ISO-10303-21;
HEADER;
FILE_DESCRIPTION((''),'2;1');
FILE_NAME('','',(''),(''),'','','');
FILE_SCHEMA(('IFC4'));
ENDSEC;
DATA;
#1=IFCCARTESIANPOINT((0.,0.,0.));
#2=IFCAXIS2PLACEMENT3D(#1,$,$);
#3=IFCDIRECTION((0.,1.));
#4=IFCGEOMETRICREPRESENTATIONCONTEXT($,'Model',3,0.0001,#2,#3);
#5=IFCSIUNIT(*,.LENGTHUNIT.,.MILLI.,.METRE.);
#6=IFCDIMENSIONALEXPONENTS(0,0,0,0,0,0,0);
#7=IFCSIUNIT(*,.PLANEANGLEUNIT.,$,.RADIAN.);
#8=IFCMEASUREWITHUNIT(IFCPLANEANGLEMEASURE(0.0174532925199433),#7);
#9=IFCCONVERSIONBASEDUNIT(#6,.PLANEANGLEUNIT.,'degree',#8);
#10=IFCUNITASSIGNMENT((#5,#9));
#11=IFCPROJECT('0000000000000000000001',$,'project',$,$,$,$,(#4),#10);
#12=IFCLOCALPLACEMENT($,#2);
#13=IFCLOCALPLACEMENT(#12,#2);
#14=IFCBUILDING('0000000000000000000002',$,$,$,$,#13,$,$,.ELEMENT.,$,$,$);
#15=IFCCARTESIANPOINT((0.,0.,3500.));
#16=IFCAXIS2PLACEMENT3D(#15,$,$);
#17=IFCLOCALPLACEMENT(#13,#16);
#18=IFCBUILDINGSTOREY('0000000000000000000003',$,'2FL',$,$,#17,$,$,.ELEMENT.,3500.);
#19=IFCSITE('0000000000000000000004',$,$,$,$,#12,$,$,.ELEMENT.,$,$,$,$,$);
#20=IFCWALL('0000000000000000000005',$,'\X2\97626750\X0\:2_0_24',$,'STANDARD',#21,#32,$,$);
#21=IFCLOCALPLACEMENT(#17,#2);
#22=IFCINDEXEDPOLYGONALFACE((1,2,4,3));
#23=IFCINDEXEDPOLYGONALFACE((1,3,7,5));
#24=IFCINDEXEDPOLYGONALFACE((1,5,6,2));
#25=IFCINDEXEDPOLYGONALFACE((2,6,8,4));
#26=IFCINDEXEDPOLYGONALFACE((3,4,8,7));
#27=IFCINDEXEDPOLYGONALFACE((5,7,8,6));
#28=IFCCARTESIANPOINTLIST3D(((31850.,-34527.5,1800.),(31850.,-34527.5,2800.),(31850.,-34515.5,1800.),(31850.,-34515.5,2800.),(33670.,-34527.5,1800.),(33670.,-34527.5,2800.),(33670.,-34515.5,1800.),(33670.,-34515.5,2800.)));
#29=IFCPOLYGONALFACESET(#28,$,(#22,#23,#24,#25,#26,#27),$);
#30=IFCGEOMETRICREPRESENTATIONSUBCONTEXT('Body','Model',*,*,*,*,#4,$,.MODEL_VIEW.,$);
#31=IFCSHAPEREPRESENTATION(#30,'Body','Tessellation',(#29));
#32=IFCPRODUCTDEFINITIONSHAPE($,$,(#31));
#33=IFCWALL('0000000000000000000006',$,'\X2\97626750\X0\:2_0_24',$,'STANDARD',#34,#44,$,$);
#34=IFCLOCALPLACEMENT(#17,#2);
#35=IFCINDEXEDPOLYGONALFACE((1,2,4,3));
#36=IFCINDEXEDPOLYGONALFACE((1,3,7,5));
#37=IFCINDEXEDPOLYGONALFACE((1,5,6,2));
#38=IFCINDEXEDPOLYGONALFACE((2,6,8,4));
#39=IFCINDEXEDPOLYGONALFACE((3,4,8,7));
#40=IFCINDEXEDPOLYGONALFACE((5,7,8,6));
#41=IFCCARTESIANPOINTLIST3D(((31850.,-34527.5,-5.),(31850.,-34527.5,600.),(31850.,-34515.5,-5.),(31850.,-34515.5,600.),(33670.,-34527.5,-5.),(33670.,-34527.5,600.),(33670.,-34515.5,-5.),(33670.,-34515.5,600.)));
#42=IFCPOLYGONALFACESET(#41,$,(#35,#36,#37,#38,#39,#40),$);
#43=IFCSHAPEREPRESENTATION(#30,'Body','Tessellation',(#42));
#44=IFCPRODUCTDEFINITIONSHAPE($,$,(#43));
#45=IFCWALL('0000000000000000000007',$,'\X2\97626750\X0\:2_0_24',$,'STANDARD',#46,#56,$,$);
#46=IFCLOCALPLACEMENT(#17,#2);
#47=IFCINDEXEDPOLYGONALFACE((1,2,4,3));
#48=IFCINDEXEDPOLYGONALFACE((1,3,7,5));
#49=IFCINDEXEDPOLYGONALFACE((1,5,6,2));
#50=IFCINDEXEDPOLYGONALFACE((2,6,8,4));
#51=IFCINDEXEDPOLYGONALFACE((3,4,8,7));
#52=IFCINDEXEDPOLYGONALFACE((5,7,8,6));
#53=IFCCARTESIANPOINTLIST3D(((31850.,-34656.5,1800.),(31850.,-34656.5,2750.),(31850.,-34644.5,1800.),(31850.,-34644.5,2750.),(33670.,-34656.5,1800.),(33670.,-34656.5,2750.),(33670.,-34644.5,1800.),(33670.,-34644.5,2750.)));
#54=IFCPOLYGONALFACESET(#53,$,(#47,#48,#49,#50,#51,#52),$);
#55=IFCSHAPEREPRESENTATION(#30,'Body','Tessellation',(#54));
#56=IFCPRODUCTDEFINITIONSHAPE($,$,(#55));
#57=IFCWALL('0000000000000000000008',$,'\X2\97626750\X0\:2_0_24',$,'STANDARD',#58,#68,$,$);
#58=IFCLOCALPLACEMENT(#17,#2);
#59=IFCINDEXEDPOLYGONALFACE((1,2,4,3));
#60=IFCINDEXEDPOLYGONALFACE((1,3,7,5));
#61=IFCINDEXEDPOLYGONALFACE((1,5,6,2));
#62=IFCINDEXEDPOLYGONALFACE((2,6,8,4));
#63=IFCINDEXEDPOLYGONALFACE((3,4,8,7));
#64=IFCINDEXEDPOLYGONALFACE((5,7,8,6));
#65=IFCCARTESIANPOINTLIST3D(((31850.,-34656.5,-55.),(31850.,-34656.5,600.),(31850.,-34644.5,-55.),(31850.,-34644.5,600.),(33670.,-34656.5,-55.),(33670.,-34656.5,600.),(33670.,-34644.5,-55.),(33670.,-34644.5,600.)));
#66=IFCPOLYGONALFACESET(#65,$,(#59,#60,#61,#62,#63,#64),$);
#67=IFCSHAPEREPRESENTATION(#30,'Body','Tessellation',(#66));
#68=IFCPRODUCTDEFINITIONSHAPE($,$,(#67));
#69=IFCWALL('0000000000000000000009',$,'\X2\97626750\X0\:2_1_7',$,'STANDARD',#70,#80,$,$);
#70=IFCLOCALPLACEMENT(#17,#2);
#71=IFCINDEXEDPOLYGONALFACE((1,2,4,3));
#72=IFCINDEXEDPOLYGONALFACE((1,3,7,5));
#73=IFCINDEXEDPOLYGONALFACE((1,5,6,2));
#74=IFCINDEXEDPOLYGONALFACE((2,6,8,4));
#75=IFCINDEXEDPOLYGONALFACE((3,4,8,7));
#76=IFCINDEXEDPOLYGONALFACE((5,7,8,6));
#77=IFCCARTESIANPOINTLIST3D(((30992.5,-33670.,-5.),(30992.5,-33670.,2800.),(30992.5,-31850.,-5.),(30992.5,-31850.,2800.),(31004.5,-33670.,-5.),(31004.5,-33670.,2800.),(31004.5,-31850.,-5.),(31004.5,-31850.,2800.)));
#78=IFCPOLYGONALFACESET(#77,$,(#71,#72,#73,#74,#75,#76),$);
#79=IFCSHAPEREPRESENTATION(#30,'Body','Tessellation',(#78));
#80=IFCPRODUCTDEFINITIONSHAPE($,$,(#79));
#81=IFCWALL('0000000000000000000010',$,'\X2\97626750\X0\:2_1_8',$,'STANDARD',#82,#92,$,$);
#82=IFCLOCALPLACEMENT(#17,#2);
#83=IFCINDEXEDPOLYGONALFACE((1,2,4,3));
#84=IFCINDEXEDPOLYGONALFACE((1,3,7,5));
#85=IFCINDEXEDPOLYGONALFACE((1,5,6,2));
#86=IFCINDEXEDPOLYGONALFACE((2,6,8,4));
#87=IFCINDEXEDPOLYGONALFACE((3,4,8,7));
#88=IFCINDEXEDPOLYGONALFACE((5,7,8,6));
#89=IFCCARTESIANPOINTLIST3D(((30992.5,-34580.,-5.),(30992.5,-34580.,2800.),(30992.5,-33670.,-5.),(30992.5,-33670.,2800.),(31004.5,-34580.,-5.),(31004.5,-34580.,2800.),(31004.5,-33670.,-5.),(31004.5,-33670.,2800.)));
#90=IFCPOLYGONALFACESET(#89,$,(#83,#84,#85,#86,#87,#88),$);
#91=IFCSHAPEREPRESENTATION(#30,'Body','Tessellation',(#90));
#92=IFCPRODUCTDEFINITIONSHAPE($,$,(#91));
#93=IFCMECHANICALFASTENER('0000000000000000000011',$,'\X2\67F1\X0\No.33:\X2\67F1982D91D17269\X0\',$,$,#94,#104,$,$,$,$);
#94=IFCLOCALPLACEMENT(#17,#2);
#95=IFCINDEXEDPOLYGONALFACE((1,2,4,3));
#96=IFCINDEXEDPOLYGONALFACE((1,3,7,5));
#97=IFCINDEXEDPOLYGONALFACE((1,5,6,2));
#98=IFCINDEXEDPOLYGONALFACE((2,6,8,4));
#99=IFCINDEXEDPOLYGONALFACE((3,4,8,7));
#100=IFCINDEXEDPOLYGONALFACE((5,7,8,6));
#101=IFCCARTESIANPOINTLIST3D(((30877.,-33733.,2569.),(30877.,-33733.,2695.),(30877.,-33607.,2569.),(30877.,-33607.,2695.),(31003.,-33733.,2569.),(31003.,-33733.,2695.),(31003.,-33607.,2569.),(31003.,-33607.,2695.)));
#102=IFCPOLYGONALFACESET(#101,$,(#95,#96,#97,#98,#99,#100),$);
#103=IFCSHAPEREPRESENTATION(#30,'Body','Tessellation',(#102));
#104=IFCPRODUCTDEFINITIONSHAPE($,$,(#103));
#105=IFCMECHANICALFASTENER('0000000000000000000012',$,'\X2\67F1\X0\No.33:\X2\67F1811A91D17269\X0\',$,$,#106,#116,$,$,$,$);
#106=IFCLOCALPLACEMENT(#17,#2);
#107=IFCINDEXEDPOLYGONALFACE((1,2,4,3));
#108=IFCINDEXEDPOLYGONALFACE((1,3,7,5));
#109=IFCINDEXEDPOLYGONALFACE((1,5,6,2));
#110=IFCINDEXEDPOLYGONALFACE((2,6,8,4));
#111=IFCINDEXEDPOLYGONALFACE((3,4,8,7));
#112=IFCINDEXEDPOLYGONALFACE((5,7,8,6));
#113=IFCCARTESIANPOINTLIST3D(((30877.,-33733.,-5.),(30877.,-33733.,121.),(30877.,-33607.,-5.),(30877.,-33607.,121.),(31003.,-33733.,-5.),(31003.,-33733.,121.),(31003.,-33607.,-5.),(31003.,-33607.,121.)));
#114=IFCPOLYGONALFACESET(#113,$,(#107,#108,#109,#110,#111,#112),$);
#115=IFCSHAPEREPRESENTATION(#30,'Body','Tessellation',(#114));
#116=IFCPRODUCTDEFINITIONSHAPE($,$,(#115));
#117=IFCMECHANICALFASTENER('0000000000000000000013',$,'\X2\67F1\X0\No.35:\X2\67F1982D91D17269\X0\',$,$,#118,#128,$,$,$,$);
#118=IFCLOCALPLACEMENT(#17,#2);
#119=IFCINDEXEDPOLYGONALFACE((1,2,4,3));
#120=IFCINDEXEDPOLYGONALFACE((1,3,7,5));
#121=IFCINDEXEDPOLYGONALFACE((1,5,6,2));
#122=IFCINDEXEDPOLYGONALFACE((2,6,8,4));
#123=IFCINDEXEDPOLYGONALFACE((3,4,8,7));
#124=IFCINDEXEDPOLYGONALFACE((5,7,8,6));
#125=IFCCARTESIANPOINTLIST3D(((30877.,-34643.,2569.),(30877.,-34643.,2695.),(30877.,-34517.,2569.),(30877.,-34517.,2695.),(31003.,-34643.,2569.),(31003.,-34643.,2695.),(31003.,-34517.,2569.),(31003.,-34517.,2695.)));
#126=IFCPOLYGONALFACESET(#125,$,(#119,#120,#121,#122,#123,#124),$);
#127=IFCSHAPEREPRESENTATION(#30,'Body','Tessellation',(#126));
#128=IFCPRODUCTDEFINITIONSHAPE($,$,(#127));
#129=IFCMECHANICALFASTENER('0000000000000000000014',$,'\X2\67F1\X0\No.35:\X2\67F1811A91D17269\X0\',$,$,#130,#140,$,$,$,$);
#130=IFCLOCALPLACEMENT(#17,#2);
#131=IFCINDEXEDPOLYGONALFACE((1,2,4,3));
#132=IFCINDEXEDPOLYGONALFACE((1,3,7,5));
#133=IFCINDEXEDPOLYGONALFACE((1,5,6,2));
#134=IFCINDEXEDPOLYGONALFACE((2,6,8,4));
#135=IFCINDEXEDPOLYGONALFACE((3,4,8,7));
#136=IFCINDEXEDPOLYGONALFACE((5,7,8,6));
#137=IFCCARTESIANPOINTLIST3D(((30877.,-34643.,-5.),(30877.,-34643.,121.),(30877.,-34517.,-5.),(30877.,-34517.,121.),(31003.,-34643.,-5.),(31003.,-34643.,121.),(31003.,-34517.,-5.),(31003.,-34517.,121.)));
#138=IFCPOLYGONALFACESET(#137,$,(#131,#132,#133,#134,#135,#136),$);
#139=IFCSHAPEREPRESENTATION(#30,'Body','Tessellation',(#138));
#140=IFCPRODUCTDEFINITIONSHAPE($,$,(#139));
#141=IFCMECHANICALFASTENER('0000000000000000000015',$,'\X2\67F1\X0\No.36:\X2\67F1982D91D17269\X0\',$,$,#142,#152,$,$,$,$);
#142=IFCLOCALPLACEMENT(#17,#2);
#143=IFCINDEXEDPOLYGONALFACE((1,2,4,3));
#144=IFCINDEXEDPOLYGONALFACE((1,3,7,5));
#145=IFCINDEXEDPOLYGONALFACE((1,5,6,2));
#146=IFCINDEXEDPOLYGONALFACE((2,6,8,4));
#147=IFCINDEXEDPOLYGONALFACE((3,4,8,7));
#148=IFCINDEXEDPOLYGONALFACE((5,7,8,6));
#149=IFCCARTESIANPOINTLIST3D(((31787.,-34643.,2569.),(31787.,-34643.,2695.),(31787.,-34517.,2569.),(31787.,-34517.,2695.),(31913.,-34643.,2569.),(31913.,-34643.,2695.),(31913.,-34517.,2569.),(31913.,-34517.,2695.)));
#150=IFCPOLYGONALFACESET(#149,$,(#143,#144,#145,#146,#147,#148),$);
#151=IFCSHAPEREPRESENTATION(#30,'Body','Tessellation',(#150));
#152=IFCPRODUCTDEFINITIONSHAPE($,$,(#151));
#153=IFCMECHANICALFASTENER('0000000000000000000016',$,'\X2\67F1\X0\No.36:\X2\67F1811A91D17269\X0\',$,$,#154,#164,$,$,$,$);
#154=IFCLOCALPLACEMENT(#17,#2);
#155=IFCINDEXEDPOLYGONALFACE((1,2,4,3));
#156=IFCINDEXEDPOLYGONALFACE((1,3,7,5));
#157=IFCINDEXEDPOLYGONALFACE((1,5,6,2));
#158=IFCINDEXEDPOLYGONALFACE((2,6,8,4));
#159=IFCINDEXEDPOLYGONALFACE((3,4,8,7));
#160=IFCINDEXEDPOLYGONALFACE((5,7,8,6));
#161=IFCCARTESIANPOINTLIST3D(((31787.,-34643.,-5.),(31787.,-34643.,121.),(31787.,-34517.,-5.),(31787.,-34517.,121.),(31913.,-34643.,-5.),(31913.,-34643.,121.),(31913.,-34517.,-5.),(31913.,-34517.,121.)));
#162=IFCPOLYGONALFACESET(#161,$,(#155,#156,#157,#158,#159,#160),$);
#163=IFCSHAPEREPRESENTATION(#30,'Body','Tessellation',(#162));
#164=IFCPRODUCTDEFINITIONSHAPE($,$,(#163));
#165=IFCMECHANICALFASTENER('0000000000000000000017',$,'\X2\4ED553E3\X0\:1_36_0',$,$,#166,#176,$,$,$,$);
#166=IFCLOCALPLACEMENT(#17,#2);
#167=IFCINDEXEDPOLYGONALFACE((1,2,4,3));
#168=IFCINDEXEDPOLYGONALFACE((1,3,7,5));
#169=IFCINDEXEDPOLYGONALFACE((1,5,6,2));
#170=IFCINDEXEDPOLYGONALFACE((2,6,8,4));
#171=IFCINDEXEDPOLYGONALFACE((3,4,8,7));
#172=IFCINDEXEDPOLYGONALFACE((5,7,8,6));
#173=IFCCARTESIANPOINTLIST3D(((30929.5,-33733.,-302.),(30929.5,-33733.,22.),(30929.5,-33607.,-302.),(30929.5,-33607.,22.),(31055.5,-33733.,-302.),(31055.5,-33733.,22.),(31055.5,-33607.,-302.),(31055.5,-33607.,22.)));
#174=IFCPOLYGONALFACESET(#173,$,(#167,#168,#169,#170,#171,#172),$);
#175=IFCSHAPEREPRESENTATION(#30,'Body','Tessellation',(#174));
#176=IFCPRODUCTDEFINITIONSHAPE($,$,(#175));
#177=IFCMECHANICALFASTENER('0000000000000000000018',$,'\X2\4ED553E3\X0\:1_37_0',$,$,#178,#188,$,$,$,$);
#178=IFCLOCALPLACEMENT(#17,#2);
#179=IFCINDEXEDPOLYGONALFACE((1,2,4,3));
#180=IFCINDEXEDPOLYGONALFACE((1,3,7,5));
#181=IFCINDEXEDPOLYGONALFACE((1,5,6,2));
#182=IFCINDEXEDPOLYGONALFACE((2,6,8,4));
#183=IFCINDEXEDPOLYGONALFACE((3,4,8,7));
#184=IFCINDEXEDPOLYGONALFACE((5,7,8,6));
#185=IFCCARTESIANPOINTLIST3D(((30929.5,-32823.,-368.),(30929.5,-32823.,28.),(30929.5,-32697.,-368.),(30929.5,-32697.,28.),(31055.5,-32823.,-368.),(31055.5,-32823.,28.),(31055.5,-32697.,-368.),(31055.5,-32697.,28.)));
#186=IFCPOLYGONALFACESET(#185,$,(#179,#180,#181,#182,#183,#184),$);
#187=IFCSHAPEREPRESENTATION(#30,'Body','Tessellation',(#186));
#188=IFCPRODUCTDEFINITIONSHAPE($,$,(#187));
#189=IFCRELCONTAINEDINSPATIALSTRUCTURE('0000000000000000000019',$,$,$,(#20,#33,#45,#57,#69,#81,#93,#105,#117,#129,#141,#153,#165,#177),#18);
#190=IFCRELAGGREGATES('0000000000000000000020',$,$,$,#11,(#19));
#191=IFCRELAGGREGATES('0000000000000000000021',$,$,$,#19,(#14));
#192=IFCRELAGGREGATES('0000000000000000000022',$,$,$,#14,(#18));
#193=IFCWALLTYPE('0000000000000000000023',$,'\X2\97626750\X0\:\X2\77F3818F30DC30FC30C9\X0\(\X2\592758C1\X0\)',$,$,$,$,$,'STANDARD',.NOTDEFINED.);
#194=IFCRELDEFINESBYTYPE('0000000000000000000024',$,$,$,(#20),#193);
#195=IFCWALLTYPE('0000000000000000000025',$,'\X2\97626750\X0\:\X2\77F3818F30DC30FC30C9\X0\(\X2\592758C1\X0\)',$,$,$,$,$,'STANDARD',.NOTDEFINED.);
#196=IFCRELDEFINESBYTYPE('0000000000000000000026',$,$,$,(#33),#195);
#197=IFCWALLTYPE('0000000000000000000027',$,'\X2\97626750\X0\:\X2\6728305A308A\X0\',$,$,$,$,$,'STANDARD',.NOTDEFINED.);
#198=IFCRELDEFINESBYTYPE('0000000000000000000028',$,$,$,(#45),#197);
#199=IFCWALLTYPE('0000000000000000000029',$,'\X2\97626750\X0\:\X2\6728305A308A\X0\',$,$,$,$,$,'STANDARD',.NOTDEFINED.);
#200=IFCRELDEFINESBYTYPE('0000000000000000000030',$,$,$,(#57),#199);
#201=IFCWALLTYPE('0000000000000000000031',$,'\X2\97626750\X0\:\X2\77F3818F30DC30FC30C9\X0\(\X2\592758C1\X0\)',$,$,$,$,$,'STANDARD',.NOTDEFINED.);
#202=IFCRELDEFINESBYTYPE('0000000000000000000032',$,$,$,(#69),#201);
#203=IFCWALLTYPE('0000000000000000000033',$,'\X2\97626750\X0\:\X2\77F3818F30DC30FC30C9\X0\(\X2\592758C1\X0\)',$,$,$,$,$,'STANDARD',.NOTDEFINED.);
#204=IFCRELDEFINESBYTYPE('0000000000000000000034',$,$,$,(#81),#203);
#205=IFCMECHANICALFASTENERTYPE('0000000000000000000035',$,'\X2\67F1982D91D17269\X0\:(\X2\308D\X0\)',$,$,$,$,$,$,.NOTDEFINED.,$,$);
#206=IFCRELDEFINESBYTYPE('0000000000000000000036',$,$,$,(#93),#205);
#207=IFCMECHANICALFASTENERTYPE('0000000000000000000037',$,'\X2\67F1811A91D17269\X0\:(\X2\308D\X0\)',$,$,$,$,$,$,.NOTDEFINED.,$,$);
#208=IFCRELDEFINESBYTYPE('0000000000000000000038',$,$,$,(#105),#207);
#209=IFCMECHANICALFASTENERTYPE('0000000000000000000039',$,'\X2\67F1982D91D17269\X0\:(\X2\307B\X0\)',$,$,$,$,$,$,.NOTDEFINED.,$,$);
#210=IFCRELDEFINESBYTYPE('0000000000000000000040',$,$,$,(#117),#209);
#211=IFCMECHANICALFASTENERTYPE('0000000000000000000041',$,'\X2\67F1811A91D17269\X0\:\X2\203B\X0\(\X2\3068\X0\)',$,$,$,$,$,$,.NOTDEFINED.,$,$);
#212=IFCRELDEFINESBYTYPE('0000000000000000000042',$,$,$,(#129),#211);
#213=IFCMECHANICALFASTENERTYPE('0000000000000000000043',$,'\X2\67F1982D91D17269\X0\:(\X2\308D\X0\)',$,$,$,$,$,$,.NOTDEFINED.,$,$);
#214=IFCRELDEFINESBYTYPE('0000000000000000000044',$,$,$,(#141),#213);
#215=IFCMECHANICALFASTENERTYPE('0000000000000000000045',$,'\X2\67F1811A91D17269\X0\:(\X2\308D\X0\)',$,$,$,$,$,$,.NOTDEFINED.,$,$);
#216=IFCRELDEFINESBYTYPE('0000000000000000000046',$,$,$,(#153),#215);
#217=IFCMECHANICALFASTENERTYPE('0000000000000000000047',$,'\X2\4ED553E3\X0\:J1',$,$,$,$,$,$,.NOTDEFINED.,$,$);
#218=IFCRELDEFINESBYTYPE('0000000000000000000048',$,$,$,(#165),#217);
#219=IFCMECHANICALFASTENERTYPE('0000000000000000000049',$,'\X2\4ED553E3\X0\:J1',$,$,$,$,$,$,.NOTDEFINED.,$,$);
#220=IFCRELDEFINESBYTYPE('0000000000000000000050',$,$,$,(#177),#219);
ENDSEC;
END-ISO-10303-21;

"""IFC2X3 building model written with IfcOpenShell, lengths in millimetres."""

from ifc_helpers import new_model, entity, si_unit, converted_unit, direction, frame, origin, origin_with_axes, origin_2d, place, context, subcontext, project, spatial, polyline, rectangle, outline, extrude, type_object, element, save


model = new_model("IFC2X3")

# Units and contexts
model_context = context("Model", 3, precision=0.0001, world=origin(), true_north=direction((0.0, 1.0)))
body_context = subcontext(model_context, "Body", "Model", "MODEL_VIEW")
ifc_project = project(units=[si_unit("LENGTHUNIT", "METRE", prefix="MILLI"), converted_unit("PLANEANGLEUNIT", "degree", entity("IfcPlaneAngleMeasure", 0.0174532925199433), si_unit("PLANEANGLEUNIT", "RADIAN"), dimensions=[0, 0, 0, 0, 0, 0, 0])], contexts=[model_context])

# Site, building, storey
site_placement = place(None, origin())
site = spatial("IfcSite", under=ifc_project, at=site_placement, CompositionType="ELEMENT")
building_placement = place(site_placement, origin())
building = spatial("IfcBuilding", under=site, at=building_placement, CompositionType="ELEMENT")
storey_placement = place(building_placement, frame((0.0, 0.0, 3500.0)))
storey = spatial("IfcBuildingStorey", under=building, at=storey_placement, Name="2FL", CompositionType="ELEMENT", Elevation=3500.0)

# Walls
wall_type_1 = type_object("IfcWallType", Name="面材:石膏ボード(大壁)", ElementType="STANDARD", PredefinedType="NOTDEFINED")
wall_1_placement = place(storey_placement, frame((32760.0, -34515.5, 1800.0), z_axis=(0.0, -1.0, 0.0), x_axis=(1.0, 0.0, 0.0)))
element("IfcWall", 1, at=wall_1_placement, inside=storey, type_object=wall_type_1, Name="面材:2_0_24", ObjectType="STANDARD", context=body_context, shape_type="SweptSolid", body=[
    extrude(outline(polyline([(-910.0, 0.0, 0.0), (-910.0, 1000.0, 0.0), (910.0, 1000.0, 0.0), (910.0, 0.0, 0.0), (-910.0, 0.0, 0.0)])), origin_with_axes(), (0.0, 0.0, 1.0), 12.0),
])
wall_type_2 = type_object("IfcWallType", Name="面材:石膏ボード(大壁)", ElementType="STANDARD", PredefinedType="NOTDEFINED")
wall_2_placement = place(storey_placement, frame((32760.0, -34515.5, -5.0), z_axis=(0.0, -1.0, 0.0), x_axis=(1.0, 0.0, 0.0)))
element("IfcWall", 2, at=wall_2_placement, inside=storey, type_object=wall_type_2, Name="面材:2_0_24", ObjectType="STANDARD", context=body_context, shape_type="SweptSolid", body=[
    extrude(outline(polyline([(-910.0, 605.0, 0.0), (910.0, 605.0, 0.0), (910.0, 0.0, 0.0), (-910.0, 0.0, 0.0), (-910.0, 605.0, 0.0)])), origin_with_axes(), (0.0, 0.0, 1.0), 12.0),
])
wall_type_3 = type_object("IfcWallType", Name="面材:木ずり", ElementType="STANDARD", PredefinedType="NOTDEFINED")
wall_3_placement = place(storey_placement, frame((32760.0, -34644.5, 1800.0), z_axis=(0.0, -1.0, 0.0), x_axis=(1.0, 0.0, 0.0)))
element("IfcWall", 3, at=wall_3_placement, inside=storey, type_object=wall_type_3, Name="面材:2_0_24", ObjectType="STANDARD", context=body_context, shape_type="SweptSolid", body=[
    extrude(outline(polyline([(-910.0, 0.0, 0.0), (-910.0, 950.0, 0.0), (910.0, 950.0, 0.0), (910.0, 0.0, 0.0), (-910.0, 0.0, 0.0)])), origin_with_axes(), (0.0, 0.0, 1.0), 12.0),
])
wall_type_4 = type_object("IfcWallType", Name="面材:木ずり", ElementType="STANDARD", PredefinedType="NOTDEFINED")
wall_4_placement = place(storey_placement, frame((32760.0, -34644.5, -55.0), z_axis=(0.0, -1.0, 0.0), x_axis=(1.0, 0.0, 0.0)))
element("IfcWall", 4, at=wall_4_placement, inside=storey, type_object=wall_type_4, Name="面材:2_0_24", ObjectType="STANDARD", context=body_context, shape_type="SweptSolid", body=[
    extrude(outline(polyline([(-910.0, 655.0, 0.0), (910.0, 655.0, 0.0), (910.0, 0.0, 0.0), (-910.0, 0.0, 0.0), (-910.0, 655.0, 0.0)])), origin_with_axes(), (0.0, 0.0, 1.0), 12.0),
])
wall_type_5 = type_object("IfcWallType", Name="面材:石膏ボード(大壁)", ElementType="STANDARD", PredefinedType="NOTDEFINED")
wall_5_placement = place(storey_placement, frame((31004.5, -32760.0, -5.0), z_axis=(-1.0, 0.0, 0.0), x_axis=(0.0, -1.0, 0.0)))
element("IfcWall", 5, at=wall_5_placement, inside=storey, type_object=wall_type_5, Name="面材:2_1_7", ObjectType="STANDARD", context=body_context, shape_type="SweptSolid", body=[
    extrude(outline(polyline([(910.0, 0.0, 0.0), (-910.0, 0.0, 0.0), (-910.0, 2805.0, 0.0), (910.0, 2805.0, 0.0), (910.0, 0.0, 0.0)])), origin_with_axes(), (0.0, 0.0, 1.0), 12.0),
])
wall_type_6 = type_object("IfcWallType", Name="面材:石膏ボード(大壁)", ElementType="STANDARD", PredefinedType="NOTDEFINED")
wall_6_placement = place(storey_placement, frame((31004.5, -34125.0, -5.0), z_axis=(-1.0, 0.0, 0.0), x_axis=(0.0, -1.0, 0.0)))
element("IfcWall", 6, at=wall_6_placement, inside=storey, type_object=wall_type_6, Name="面材:2_1_8", ObjectType="STANDARD", context=body_context, shape_type="SweptSolid", body=[
    extrude(outline(polyline([(455.0, 0.0, 0.0), (-455.0, 0.0, 0.0), (-455.0, 2805.0, 0.0), (455.0, 2805.0, 0.0), (455.0, 0.0, 0.0)])), origin_with_axes(), (0.0, 0.0, 1.0), 12.0),
])

# Mechanical fasteners
mechanical_fastener_type_1 = type_object("IfcMechanicalFastenerType", Name="柱頭金物:(ろ)")
mechanical_fastener_1_placement = place(storey_placement, frame((30940.0, -33670.0, 2569.0)))
element("IfcMechanicalFastener", 7, at=mechanical_fastener_1_placement, inside=storey, type_object=mechanical_fastener_type_1, Name="柱No.33:柱頭金物", context=body_context, shape_type="SweptSolid", body=[
    extrude(rectangle(XDim=126.0, YDim=126.0, at=origin_2d()), origin_with_axes(), (0.0, 0.0, 1.0), 126.0),
])
mechanical_fastener_type_2 = type_object("IfcMechanicalFastenerType", Name="柱脚金物:(ろ)")
mechanical_fastener_2_placement = place(storey_placement, frame((30940.0, -33670.0, -5.0)))
element("IfcMechanicalFastener", 8, at=mechanical_fastener_2_placement, inside=storey, type_object=mechanical_fastener_type_2, Name="柱No.33:柱脚金物", context=body_context, shape_type="SweptSolid", body=[
    extrude(rectangle(XDim=126.0, YDim=126.0, at=origin_2d()), origin_with_axes(), (0.0, 0.0, 1.0), 126.0),
])
mechanical_fastener_type_3 = type_object("IfcMechanicalFastenerType", Name="柱頭金物:(ほ)")
mechanical_fastener_3_placement = place(storey_placement, frame((30940.0, -34580.0, 2569.0)))
element("IfcMechanicalFastener", 9, at=mechanical_fastener_3_placement, inside=storey, type_object=mechanical_fastener_type_3, Name="柱No.35:柱頭金物", context=body_context, shape_type="SweptSolid", body=[
    extrude(rectangle(XDim=126.0, YDim=126.0, at=origin_2d()), origin_with_axes(), (0.0, 0.0, 1.0), 126.0),
])
mechanical_fastener_type_4 = type_object("IfcMechanicalFastenerType", Name="柱脚金物:※(と)")
mechanical_fastener_4_placement = place(storey_placement, frame((30940.0, -34580.0, -5.0)))
element("IfcMechanicalFastener", 10, at=mechanical_fastener_4_placement, inside=storey, type_object=mechanical_fastener_type_4, Name="柱No.35:柱脚金物", context=body_context, shape_type="SweptSolid", body=[
    extrude(rectangle(XDim=126.0, YDim=126.0, at=origin_2d()), origin_with_axes(), (0.0, 0.0, 1.0), 126.0),
])
mechanical_fastener_type_5 = type_object("IfcMechanicalFastenerType", Name="柱頭金物:(ろ)")
mechanical_fastener_5_placement = place(storey_placement, frame((31850.0, -34580.0, 2569.0)))
element("IfcMechanicalFastener", 11, at=mechanical_fastener_5_placement, inside=storey, type_object=mechanical_fastener_type_5, Name="柱No.36:柱頭金物", context=body_context, shape_type="SweptSolid", body=[
    extrude(rectangle(XDim=126.0, YDim=126.0, at=origin_2d()), origin_with_axes(), (0.0, 0.0, 1.0), 126.0),
])
mechanical_fastener_type_6 = type_object("IfcMechanicalFastenerType", Name="柱脚金物:(ろ)")
mechanical_fastener_6_placement = place(storey_placement, frame((31850.0, -34580.0, -5.0)))
element("IfcMechanicalFastener", 12, at=mechanical_fastener_6_placement, inside=storey, type_object=mechanical_fastener_type_6, Name="柱No.36:柱脚金物", context=body_context, shape_type="SweptSolid", body=[
    extrude(rectangle(XDim=126.0, YDim=126.0, at=origin_2d()), origin_with_axes(), (0.0, 0.0, 1.0), 126.0),
])
mechanical_fastener_type_7 = type_object("IfcMechanicalFastenerType", Name="仕口:J1")
mechanical_fastener_7_placement = place(storey_placement, frame((30992.5, -33670.0, -302.0)))
element("IfcMechanicalFastener", 13, at=mechanical_fastener_7_placement, inside=storey, type_object=mechanical_fastener_type_7, Name="仕口:1_36_0", context=body_context, shape_type="SweptSolid", body=[
    extrude(rectangle(XDim=126.0, YDim=126.0, at=origin_2d()), origin_with_axes(), (0.0, 0.0, 1.0), 324.0),
])
mechanical_fastener_type_8 = type_object("IfcMechanicalFastenerType", Name="仕口:J1")
mechanical_fastener_8_placement = place(storey_placement, frame((30992.5, -32760.0, -368.0)))
element("IfcMechanicalFastener", 14, at=mechanical_fastener_8_placement, inside=storey, type_object=mechanical_fastener_type_8, Name="仕口:1_37_0", context=body_context, shape_type="SweptSolid", body=[
    extrude(rectangle(XDim=126.0, YDim=126.0, at=origin_2d()), origin_with_axes(), (0.0, 0.0, 1.0), 396.0),
])

save(model, "model.ifc")
